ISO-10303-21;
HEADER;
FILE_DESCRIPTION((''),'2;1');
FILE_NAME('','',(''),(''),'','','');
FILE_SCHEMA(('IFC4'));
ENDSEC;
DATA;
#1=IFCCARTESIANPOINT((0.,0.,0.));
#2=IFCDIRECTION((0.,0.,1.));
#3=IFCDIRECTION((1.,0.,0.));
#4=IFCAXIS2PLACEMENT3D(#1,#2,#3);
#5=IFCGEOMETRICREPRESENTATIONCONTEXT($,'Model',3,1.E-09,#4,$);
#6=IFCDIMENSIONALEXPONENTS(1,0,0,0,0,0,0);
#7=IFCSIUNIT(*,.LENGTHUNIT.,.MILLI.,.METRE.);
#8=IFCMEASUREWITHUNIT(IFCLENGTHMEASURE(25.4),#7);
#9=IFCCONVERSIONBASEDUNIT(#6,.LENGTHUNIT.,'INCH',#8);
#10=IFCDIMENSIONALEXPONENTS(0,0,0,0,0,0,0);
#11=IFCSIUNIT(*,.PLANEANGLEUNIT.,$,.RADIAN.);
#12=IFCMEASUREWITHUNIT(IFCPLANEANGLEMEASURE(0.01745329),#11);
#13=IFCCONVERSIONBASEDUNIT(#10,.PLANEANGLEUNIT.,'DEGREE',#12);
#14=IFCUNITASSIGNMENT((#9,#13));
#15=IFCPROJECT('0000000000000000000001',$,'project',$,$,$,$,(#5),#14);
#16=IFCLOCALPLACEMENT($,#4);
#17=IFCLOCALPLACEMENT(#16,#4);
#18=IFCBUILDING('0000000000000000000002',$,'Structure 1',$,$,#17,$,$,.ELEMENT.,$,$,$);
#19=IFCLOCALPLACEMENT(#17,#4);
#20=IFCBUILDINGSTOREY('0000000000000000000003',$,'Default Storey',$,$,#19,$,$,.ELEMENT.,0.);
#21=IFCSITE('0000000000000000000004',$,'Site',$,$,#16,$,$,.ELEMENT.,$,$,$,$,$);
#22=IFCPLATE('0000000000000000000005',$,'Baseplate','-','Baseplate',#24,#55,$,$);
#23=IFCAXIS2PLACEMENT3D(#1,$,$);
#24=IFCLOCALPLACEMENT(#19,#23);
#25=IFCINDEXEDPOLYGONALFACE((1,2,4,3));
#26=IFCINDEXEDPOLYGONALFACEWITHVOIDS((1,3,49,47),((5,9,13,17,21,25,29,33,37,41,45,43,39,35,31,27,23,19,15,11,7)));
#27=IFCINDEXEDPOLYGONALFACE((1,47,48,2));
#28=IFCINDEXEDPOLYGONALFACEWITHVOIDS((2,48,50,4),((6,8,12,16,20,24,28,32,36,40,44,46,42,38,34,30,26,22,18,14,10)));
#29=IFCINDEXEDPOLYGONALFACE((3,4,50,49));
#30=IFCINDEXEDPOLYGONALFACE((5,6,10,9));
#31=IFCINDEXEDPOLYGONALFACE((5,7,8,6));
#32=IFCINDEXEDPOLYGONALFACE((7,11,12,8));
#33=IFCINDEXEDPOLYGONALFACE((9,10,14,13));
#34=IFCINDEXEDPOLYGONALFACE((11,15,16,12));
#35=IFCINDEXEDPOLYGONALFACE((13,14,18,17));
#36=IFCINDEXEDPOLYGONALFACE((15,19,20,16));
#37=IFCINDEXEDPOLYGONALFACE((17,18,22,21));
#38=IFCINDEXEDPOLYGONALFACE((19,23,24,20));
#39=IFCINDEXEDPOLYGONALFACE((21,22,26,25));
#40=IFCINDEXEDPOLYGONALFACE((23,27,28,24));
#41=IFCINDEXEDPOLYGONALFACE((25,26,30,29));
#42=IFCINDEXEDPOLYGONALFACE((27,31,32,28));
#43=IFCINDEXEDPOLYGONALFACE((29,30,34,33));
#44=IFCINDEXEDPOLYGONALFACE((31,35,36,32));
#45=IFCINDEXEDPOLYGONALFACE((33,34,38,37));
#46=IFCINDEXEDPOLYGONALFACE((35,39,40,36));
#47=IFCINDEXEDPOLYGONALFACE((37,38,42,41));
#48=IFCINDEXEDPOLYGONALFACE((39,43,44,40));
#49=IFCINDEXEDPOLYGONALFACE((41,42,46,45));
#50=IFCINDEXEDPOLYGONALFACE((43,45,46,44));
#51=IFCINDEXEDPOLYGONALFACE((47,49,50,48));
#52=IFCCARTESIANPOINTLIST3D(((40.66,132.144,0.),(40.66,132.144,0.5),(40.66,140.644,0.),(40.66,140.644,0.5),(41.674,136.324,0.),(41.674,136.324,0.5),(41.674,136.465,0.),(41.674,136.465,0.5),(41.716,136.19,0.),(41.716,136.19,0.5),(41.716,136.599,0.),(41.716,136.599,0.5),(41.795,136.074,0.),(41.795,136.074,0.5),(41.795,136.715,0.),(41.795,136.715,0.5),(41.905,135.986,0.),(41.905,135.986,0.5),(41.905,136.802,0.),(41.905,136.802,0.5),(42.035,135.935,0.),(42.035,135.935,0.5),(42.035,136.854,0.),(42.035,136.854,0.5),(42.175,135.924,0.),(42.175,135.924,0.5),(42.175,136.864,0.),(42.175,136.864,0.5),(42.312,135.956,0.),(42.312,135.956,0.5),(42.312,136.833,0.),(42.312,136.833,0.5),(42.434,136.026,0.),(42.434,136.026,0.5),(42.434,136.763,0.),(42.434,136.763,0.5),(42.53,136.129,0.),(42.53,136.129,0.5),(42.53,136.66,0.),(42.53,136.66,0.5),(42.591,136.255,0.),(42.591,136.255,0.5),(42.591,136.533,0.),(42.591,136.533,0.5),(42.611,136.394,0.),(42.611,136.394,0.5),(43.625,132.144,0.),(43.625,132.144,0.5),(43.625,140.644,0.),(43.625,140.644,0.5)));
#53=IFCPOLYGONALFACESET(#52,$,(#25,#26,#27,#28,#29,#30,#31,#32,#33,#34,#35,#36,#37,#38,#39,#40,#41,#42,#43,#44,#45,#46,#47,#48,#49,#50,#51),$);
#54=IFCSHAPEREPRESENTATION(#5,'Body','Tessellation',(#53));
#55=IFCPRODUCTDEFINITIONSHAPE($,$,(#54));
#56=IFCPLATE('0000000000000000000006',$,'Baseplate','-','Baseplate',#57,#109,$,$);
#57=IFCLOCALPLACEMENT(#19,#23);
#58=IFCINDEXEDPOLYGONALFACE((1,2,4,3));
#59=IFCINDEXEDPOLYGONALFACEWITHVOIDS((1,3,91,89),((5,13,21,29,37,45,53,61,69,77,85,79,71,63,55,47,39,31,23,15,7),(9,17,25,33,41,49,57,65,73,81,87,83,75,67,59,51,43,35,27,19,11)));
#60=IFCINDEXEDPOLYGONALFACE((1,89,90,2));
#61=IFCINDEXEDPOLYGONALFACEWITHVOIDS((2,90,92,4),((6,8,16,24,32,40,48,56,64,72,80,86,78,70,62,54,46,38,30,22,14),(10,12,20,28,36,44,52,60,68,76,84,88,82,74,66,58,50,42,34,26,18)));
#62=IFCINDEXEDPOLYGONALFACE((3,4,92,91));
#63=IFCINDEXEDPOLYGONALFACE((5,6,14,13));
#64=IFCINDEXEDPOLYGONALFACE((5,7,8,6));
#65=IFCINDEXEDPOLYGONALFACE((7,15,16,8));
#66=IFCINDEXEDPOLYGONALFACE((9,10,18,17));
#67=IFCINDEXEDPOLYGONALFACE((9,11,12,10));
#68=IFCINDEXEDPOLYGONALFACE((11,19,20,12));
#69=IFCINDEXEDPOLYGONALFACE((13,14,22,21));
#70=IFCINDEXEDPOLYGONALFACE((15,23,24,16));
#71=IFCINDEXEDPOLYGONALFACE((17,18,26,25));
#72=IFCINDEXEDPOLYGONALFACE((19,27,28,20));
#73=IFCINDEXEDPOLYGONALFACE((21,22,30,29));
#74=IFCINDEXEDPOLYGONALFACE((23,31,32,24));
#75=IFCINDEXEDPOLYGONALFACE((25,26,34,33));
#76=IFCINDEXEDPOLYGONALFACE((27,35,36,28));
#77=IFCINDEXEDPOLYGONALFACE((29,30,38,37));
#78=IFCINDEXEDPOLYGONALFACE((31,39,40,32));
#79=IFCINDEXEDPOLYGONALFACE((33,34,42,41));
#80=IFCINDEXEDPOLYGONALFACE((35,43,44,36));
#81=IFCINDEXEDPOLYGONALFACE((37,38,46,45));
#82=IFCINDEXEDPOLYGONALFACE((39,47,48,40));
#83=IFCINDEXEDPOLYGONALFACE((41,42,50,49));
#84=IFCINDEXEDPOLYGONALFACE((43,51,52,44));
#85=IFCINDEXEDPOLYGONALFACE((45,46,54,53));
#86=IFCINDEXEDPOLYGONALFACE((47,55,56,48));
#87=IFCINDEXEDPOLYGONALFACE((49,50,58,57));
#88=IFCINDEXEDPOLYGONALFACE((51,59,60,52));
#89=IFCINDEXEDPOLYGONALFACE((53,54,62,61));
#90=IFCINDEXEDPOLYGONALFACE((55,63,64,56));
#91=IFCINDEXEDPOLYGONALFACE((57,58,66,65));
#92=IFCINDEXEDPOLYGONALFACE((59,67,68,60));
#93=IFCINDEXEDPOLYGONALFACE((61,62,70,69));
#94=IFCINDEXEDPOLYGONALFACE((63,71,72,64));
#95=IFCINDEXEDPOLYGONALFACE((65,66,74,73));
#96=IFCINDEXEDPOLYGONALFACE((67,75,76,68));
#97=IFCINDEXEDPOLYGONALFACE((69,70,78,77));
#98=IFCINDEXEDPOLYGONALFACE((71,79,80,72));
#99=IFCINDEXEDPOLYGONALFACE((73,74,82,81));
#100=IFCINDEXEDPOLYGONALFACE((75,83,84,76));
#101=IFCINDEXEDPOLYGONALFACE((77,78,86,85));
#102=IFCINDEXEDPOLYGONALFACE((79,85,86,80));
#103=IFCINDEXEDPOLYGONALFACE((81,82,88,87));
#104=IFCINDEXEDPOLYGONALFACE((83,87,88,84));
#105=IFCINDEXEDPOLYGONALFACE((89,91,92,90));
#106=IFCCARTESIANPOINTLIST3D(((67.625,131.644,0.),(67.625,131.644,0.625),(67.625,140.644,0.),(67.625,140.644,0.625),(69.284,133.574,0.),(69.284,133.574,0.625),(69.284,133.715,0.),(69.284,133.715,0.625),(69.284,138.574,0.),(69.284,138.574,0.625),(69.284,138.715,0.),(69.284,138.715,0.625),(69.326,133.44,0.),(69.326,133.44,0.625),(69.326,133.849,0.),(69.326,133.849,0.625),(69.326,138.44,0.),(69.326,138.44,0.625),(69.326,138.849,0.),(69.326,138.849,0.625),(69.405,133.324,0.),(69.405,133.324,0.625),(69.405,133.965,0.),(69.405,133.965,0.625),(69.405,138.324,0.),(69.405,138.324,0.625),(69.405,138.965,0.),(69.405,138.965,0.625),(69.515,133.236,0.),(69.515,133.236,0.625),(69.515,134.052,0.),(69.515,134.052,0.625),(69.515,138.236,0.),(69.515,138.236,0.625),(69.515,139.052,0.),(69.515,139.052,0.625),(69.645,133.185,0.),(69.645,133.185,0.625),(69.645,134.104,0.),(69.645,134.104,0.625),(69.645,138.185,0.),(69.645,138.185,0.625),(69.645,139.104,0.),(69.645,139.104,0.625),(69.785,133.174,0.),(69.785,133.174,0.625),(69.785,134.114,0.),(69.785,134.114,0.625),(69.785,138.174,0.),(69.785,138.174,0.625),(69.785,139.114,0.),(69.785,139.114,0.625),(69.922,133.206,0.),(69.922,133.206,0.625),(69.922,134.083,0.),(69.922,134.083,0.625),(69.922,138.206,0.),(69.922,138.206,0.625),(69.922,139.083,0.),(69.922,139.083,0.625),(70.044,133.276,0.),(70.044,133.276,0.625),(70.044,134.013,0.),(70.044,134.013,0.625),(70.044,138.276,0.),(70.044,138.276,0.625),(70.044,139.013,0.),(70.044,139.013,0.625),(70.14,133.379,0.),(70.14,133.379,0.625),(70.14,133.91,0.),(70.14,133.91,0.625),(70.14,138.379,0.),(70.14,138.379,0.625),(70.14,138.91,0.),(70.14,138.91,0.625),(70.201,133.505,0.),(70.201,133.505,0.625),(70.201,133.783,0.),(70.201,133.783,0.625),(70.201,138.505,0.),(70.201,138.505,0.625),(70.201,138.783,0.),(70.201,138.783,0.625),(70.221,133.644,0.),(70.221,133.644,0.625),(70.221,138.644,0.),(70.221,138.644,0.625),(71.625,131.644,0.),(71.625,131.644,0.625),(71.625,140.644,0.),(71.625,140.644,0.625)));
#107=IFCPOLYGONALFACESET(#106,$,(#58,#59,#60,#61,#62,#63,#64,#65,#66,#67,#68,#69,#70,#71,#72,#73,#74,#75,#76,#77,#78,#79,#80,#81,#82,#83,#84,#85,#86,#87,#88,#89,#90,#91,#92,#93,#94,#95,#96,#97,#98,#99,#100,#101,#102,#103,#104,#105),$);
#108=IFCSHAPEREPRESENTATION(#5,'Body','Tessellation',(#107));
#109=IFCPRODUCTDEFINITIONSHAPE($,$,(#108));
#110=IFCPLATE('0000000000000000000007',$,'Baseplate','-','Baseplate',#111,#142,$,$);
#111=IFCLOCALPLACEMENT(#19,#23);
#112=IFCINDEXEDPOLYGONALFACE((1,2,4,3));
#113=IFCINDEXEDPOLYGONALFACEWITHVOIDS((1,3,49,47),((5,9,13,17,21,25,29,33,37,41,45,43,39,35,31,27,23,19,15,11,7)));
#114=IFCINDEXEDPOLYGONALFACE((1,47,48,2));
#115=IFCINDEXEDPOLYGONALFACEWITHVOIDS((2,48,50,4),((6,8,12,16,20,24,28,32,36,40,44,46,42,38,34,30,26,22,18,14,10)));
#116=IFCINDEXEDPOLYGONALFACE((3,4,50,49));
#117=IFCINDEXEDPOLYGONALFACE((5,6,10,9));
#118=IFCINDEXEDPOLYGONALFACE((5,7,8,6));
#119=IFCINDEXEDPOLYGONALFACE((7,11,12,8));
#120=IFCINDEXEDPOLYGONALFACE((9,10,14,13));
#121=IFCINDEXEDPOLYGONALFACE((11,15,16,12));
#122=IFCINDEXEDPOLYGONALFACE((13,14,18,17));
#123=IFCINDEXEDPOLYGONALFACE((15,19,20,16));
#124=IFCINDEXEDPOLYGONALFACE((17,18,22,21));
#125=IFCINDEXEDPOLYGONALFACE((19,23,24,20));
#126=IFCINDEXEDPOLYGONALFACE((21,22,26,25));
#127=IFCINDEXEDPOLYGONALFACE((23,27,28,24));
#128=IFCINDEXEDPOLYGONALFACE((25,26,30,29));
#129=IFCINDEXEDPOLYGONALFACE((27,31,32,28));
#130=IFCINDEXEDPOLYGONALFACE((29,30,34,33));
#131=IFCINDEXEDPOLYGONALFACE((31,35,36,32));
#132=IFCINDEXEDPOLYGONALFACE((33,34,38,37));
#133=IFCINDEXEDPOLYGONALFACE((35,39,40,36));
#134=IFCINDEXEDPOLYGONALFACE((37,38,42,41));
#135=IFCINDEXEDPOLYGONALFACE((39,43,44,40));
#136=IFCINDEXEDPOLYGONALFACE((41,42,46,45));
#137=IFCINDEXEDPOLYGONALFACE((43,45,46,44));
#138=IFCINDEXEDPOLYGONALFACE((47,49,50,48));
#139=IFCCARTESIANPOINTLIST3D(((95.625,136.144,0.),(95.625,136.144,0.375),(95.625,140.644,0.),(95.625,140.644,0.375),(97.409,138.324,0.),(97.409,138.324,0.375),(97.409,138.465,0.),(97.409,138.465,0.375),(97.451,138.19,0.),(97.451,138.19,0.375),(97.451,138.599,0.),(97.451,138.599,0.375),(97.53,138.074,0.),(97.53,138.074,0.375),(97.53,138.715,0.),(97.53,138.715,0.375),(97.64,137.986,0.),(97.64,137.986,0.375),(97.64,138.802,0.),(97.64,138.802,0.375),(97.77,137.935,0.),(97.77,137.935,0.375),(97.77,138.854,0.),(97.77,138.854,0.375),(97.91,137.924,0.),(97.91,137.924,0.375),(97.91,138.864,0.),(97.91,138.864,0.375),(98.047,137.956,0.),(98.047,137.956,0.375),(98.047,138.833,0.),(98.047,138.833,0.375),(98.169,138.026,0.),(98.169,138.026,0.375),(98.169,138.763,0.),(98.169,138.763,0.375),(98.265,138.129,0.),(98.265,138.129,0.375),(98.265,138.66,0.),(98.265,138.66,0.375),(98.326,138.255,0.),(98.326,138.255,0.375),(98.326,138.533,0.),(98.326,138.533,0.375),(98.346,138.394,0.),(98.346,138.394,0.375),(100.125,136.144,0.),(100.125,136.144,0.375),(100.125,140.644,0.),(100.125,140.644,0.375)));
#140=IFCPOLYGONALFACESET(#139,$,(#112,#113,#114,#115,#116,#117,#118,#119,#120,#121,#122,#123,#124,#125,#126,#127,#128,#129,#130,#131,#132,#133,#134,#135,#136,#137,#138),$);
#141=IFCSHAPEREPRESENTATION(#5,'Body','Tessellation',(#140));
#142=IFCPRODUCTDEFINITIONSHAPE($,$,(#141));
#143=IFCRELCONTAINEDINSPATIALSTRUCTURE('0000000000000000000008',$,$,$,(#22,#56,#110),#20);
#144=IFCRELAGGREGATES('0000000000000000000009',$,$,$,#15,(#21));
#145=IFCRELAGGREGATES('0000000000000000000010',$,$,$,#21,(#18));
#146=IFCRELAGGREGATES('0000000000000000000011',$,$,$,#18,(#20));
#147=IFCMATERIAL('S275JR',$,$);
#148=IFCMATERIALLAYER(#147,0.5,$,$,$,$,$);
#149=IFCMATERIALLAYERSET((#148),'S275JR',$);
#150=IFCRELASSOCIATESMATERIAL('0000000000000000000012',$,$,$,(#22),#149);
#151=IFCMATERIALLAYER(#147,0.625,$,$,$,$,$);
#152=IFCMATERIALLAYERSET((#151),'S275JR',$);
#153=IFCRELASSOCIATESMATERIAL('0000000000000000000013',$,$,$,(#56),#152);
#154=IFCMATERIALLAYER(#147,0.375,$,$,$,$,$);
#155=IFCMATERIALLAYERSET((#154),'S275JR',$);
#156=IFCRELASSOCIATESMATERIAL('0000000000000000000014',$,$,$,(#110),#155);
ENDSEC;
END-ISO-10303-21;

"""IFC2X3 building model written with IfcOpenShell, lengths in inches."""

from ifc_helpers import new_model, entity, si_unit, converted_unit, frame, frame_2d, origin, origin_with_axes, origin_2d_with_axis, place, context, project, spatial, polyline, circle, outline, extrude, material, layer, layer_set, element, save


model = new_model("IFC2X3")

# Units and contexts
model_context = context("Model", 3, precision=1e-09, world=origin_with_axes())
ifc_project = project(units=[converted_unit("LENGTHUNIT", "INCH", entity("IfcLengthMeasure", 25.4), si_unit("LENGTHUNIT", "METRE", prefix="MILLI"), dimensions=[1, 0, 0, 0, 0, 0, 0]), converted_unit("PLANEANGLEUNIT", "DEGREE", entity("IfcPlaneAngleMeasure", 0.01745329), si_unit("PLANEANGLEUNIT", "RADIAN"), dimensions=[0, 0, 0, 0, 0, 0, 0])], contexts=[model_context])

# Site, building, storey
site_placement = place(None, origin_with_axes())
site = spatial("IfcSite", under=ifc_project, at=site_placement, Name="Site", CompositionType="ELEMENT")
building_placement = place(site_placement, origin_with_axes())
building = spatial("IfcBuilding", under=site, at=building_placement, Name="Structure 1", CompositionType="ELEMENT")
storey_placement = place(building_placement, origin_with_axes())
storey = spatial("IfcBuildingStorey", under=building, at=storey_placement, Name="Default Storey", CompositionType="ELEMENT", Elevation=0.0)

# Plates, openings
ifc_material_1 = material(Name="S275JR")
ifc_layer_1 = layer(ifc_material_1, 0.5)
ifc_layer_set_1 = layer_set([ifc_layer_1], Name="S275JR")
plate_1_placement = place(None, frame((43.625, 132.144, 0.5), z_axis=(0.0, 0.0, -1.0), x_axis=(-1.0, 0.0, 0.0)))
plate_1 = element("IfcPlate", 1, at=plate_1_placement, inside=storey, material=ifc_layer_set_1, Name="Baseplate", Description="-", ObjectType="Baseplate", context=model_context, shape_type="SweptSolid", body=[
    extrude(outline(polyline([(0.0, 0.0), (2.965, 0.0), (2.965, 8.5), (0.0, 8.5), (0.0, 0.0)])), origin_with_axes(), (0.0, 0.0, 1.0), 0.5),
])
opening_1_placement = place(plate_1_placement, frame((1.485, 4.25, 0.52), z_axis=(0.0, 0.0, -1.0), x_axis=(1.0, 0.0, 0.0)))
element("IfcOpeningElement", 2, at=opening_1_placement, cuts=plate_1, ObjectType="Opening", context=model_context, shape_type="SweptSolid", body=[
    extrude(circle(Radius=0.433, at=origin_2d_with_axis()), origin(), (0.0, 0.0, 1.0), 0.539),
])
opening_2_placement = place(plate_1_placement, frame((1.485, 4.25, 0.52), z_axis=(0.0, 0.0, -1.0), x_axis=(-1.0, 0.0, 0.0)))
element("IfcOpeningElement", 3, at=opening_2_placement, cuts=plate_1, ObjectType="Opening", context=model_context, shape_type="SweptSolid", body=[
    extrude(circle(Radius=0.471, at=origin_2d_with_axis()), origin(), (0.0, 0.0, 1.0), 0.539),
])
ifc_layer_2 = layer(ifc_material_1, 0.625)
ifc_layer_set_2 = layer_set([ifc_layer_2], Name="S275JR")
plate_2_placement = place(None, frame((71.625, 131.644, 0.625), z_axis=(0.0, 0.0, -1.0), x_axis=(-1.0, 0.0, 0.0)))
plate_2 = element("IfcPlate", 4, at=plate_2_placement, inside=storey, material=ifc_layer_set_2, Name="Baseplate", Description="-", ObjectType="Baseplate", context=model_context, shape_type="SweptSolid", body=[
    extrude(outline(polyline([(0.0, 0.0), (4.0, 0.0), (4.0, 9.0), (0.0, 9.0), (0.0, 0.0)])), origin_with_axes(), (0.0, 0.0, 1.0), 0.625),
])
opening_3_placement = place(plate_2_placement, frame((1.875, 7.0, 0.645), z_axis=(0.0, 0.0, -1.0), x_axis=(1.0, 0.0, 0.0)))
element("IfcOpeningElement", 5, at=opening_3_placement, cuts=plate_2, ObjectType="Opening", context=model_context, shape_type="SweptSolid", body=[
    extrude(circle(Radius=0.433, at=frame_2d((0.0, 5.0), x_axis=(1.0, 0.0))), origin(), (0.0, 0.0, 1.0), 0.664),
])
opening_4_placement = place(plate_2_placement, frame((1.875, 7.0, 0.645), z_axis=(0.0, 0.0, -1.0), x_axis=(1.0, 0.0, 0.0)))
element("IfcOpeningElement", 6, at=opening_4_placement, cuts=plate_2, ObjectType="Opening", context=model_context, shape_type="SweptSolid", body=[
    extrude(circle(Radius=0.433, at=origin_2d_with_axis()), origin(), (0.0, 0.0, 1.0), 0.664),
])
opening_5_placement = place(plate_2_placement, frame((1.875, 2.0, 0.645), z_axis=(0.0, 0.0, -1.0), x_axis=(-1.0, 0.0, 0.0)))
element("IfcOpeningElement", 7, at=opening_5_placement, cuts=plate_2, ObjectType="Opening", context=model_context, shape_type="SweptSolid", body=[
    extrude(circle(Radius=0.471, at=origin_2d_with_axis()), origin(), (0.0, 0.0, 1.0), 0.664),
])
opening_6_placement = place(plate_2_placement, frame((1.875, 7.0, 0.645), z_axis=(0.0, 0.0, -1.0), x_axis=(-1.0, 0.0, 0.0)))
element("IfcOpeningElement", 8, at=opening_6_placement, cuts=plate_2, ObjectType="Opening", context=model_context, shape_type="SweptSolid", body=[
    extrude(circle(Radius=0.471, at=origin_2d_with_axis()), origin(), (0.0, 0.0, 1.0), 0.664),
])
ifc_layer_3 = layer(ifc_material_1, 0.375)
ifc_layer_set_3 = layer_set([ifc_layer_3], Name="S275JR")
plate_3_placement = place(None, frame((100.125, 140.644, 0.375), z_axis=(0.0, 0.0, -1.0), x_axis=(0.0, -1.0, 0.0)))
plate_3 = element("IfcPlate", 9, at=plate_3_placement, inside=storey, material=ifc_layer_set_3, Name="Baseplate", Description="-", ObjectType="Baseplate", context=model_context, shape_type="SweptSolid", body=[
    extrude(outline(polyline([(0.0, 0.0), (4.5, 0.0), (4.5, 4.5), (0.0, 4.5), (0.0, 0.0)])), origin_with_axes(), (0.0, 0.0, 1.0), 0.375),
])
opening_7_placement = place(plate_3_placement, frame((2.25, 2.25, 0.395), z_axis=(0.0, 0.0, -1.0), x_axis=(1.0, 0.0, 0.0)))
element("IfcOpeningElement", 10, at=opening_7_placement, cuts=plate_3, ObjectType="Opening", context=model_context, shape_type="SweptSolid", body=[
    extrude(circle(Radius=0.433, at=origin_2d_with_axis()), origin(), (0.0, 0.0, 1.0), 0.414),
])
opening_8_placement = place(plate_3_placement, frame((2.25, 2.25, 0.395), z_axis=(0.0, 0.0, -1.0), x_axis=(0.0, -1.0, 0.0)))
element("IfcOpeningElement", 11, at=opening_8_placement, cuts=plate_3, ObjectType="Opening", context=model_context, shape_type="SweptSolid", body=[
    extrude(circle(Radius=0.471, at=origin_2d_with_axis()), origin(), (0.0, 0.0, 1.0), 0.414),
])

save(model, "model.ifc")
